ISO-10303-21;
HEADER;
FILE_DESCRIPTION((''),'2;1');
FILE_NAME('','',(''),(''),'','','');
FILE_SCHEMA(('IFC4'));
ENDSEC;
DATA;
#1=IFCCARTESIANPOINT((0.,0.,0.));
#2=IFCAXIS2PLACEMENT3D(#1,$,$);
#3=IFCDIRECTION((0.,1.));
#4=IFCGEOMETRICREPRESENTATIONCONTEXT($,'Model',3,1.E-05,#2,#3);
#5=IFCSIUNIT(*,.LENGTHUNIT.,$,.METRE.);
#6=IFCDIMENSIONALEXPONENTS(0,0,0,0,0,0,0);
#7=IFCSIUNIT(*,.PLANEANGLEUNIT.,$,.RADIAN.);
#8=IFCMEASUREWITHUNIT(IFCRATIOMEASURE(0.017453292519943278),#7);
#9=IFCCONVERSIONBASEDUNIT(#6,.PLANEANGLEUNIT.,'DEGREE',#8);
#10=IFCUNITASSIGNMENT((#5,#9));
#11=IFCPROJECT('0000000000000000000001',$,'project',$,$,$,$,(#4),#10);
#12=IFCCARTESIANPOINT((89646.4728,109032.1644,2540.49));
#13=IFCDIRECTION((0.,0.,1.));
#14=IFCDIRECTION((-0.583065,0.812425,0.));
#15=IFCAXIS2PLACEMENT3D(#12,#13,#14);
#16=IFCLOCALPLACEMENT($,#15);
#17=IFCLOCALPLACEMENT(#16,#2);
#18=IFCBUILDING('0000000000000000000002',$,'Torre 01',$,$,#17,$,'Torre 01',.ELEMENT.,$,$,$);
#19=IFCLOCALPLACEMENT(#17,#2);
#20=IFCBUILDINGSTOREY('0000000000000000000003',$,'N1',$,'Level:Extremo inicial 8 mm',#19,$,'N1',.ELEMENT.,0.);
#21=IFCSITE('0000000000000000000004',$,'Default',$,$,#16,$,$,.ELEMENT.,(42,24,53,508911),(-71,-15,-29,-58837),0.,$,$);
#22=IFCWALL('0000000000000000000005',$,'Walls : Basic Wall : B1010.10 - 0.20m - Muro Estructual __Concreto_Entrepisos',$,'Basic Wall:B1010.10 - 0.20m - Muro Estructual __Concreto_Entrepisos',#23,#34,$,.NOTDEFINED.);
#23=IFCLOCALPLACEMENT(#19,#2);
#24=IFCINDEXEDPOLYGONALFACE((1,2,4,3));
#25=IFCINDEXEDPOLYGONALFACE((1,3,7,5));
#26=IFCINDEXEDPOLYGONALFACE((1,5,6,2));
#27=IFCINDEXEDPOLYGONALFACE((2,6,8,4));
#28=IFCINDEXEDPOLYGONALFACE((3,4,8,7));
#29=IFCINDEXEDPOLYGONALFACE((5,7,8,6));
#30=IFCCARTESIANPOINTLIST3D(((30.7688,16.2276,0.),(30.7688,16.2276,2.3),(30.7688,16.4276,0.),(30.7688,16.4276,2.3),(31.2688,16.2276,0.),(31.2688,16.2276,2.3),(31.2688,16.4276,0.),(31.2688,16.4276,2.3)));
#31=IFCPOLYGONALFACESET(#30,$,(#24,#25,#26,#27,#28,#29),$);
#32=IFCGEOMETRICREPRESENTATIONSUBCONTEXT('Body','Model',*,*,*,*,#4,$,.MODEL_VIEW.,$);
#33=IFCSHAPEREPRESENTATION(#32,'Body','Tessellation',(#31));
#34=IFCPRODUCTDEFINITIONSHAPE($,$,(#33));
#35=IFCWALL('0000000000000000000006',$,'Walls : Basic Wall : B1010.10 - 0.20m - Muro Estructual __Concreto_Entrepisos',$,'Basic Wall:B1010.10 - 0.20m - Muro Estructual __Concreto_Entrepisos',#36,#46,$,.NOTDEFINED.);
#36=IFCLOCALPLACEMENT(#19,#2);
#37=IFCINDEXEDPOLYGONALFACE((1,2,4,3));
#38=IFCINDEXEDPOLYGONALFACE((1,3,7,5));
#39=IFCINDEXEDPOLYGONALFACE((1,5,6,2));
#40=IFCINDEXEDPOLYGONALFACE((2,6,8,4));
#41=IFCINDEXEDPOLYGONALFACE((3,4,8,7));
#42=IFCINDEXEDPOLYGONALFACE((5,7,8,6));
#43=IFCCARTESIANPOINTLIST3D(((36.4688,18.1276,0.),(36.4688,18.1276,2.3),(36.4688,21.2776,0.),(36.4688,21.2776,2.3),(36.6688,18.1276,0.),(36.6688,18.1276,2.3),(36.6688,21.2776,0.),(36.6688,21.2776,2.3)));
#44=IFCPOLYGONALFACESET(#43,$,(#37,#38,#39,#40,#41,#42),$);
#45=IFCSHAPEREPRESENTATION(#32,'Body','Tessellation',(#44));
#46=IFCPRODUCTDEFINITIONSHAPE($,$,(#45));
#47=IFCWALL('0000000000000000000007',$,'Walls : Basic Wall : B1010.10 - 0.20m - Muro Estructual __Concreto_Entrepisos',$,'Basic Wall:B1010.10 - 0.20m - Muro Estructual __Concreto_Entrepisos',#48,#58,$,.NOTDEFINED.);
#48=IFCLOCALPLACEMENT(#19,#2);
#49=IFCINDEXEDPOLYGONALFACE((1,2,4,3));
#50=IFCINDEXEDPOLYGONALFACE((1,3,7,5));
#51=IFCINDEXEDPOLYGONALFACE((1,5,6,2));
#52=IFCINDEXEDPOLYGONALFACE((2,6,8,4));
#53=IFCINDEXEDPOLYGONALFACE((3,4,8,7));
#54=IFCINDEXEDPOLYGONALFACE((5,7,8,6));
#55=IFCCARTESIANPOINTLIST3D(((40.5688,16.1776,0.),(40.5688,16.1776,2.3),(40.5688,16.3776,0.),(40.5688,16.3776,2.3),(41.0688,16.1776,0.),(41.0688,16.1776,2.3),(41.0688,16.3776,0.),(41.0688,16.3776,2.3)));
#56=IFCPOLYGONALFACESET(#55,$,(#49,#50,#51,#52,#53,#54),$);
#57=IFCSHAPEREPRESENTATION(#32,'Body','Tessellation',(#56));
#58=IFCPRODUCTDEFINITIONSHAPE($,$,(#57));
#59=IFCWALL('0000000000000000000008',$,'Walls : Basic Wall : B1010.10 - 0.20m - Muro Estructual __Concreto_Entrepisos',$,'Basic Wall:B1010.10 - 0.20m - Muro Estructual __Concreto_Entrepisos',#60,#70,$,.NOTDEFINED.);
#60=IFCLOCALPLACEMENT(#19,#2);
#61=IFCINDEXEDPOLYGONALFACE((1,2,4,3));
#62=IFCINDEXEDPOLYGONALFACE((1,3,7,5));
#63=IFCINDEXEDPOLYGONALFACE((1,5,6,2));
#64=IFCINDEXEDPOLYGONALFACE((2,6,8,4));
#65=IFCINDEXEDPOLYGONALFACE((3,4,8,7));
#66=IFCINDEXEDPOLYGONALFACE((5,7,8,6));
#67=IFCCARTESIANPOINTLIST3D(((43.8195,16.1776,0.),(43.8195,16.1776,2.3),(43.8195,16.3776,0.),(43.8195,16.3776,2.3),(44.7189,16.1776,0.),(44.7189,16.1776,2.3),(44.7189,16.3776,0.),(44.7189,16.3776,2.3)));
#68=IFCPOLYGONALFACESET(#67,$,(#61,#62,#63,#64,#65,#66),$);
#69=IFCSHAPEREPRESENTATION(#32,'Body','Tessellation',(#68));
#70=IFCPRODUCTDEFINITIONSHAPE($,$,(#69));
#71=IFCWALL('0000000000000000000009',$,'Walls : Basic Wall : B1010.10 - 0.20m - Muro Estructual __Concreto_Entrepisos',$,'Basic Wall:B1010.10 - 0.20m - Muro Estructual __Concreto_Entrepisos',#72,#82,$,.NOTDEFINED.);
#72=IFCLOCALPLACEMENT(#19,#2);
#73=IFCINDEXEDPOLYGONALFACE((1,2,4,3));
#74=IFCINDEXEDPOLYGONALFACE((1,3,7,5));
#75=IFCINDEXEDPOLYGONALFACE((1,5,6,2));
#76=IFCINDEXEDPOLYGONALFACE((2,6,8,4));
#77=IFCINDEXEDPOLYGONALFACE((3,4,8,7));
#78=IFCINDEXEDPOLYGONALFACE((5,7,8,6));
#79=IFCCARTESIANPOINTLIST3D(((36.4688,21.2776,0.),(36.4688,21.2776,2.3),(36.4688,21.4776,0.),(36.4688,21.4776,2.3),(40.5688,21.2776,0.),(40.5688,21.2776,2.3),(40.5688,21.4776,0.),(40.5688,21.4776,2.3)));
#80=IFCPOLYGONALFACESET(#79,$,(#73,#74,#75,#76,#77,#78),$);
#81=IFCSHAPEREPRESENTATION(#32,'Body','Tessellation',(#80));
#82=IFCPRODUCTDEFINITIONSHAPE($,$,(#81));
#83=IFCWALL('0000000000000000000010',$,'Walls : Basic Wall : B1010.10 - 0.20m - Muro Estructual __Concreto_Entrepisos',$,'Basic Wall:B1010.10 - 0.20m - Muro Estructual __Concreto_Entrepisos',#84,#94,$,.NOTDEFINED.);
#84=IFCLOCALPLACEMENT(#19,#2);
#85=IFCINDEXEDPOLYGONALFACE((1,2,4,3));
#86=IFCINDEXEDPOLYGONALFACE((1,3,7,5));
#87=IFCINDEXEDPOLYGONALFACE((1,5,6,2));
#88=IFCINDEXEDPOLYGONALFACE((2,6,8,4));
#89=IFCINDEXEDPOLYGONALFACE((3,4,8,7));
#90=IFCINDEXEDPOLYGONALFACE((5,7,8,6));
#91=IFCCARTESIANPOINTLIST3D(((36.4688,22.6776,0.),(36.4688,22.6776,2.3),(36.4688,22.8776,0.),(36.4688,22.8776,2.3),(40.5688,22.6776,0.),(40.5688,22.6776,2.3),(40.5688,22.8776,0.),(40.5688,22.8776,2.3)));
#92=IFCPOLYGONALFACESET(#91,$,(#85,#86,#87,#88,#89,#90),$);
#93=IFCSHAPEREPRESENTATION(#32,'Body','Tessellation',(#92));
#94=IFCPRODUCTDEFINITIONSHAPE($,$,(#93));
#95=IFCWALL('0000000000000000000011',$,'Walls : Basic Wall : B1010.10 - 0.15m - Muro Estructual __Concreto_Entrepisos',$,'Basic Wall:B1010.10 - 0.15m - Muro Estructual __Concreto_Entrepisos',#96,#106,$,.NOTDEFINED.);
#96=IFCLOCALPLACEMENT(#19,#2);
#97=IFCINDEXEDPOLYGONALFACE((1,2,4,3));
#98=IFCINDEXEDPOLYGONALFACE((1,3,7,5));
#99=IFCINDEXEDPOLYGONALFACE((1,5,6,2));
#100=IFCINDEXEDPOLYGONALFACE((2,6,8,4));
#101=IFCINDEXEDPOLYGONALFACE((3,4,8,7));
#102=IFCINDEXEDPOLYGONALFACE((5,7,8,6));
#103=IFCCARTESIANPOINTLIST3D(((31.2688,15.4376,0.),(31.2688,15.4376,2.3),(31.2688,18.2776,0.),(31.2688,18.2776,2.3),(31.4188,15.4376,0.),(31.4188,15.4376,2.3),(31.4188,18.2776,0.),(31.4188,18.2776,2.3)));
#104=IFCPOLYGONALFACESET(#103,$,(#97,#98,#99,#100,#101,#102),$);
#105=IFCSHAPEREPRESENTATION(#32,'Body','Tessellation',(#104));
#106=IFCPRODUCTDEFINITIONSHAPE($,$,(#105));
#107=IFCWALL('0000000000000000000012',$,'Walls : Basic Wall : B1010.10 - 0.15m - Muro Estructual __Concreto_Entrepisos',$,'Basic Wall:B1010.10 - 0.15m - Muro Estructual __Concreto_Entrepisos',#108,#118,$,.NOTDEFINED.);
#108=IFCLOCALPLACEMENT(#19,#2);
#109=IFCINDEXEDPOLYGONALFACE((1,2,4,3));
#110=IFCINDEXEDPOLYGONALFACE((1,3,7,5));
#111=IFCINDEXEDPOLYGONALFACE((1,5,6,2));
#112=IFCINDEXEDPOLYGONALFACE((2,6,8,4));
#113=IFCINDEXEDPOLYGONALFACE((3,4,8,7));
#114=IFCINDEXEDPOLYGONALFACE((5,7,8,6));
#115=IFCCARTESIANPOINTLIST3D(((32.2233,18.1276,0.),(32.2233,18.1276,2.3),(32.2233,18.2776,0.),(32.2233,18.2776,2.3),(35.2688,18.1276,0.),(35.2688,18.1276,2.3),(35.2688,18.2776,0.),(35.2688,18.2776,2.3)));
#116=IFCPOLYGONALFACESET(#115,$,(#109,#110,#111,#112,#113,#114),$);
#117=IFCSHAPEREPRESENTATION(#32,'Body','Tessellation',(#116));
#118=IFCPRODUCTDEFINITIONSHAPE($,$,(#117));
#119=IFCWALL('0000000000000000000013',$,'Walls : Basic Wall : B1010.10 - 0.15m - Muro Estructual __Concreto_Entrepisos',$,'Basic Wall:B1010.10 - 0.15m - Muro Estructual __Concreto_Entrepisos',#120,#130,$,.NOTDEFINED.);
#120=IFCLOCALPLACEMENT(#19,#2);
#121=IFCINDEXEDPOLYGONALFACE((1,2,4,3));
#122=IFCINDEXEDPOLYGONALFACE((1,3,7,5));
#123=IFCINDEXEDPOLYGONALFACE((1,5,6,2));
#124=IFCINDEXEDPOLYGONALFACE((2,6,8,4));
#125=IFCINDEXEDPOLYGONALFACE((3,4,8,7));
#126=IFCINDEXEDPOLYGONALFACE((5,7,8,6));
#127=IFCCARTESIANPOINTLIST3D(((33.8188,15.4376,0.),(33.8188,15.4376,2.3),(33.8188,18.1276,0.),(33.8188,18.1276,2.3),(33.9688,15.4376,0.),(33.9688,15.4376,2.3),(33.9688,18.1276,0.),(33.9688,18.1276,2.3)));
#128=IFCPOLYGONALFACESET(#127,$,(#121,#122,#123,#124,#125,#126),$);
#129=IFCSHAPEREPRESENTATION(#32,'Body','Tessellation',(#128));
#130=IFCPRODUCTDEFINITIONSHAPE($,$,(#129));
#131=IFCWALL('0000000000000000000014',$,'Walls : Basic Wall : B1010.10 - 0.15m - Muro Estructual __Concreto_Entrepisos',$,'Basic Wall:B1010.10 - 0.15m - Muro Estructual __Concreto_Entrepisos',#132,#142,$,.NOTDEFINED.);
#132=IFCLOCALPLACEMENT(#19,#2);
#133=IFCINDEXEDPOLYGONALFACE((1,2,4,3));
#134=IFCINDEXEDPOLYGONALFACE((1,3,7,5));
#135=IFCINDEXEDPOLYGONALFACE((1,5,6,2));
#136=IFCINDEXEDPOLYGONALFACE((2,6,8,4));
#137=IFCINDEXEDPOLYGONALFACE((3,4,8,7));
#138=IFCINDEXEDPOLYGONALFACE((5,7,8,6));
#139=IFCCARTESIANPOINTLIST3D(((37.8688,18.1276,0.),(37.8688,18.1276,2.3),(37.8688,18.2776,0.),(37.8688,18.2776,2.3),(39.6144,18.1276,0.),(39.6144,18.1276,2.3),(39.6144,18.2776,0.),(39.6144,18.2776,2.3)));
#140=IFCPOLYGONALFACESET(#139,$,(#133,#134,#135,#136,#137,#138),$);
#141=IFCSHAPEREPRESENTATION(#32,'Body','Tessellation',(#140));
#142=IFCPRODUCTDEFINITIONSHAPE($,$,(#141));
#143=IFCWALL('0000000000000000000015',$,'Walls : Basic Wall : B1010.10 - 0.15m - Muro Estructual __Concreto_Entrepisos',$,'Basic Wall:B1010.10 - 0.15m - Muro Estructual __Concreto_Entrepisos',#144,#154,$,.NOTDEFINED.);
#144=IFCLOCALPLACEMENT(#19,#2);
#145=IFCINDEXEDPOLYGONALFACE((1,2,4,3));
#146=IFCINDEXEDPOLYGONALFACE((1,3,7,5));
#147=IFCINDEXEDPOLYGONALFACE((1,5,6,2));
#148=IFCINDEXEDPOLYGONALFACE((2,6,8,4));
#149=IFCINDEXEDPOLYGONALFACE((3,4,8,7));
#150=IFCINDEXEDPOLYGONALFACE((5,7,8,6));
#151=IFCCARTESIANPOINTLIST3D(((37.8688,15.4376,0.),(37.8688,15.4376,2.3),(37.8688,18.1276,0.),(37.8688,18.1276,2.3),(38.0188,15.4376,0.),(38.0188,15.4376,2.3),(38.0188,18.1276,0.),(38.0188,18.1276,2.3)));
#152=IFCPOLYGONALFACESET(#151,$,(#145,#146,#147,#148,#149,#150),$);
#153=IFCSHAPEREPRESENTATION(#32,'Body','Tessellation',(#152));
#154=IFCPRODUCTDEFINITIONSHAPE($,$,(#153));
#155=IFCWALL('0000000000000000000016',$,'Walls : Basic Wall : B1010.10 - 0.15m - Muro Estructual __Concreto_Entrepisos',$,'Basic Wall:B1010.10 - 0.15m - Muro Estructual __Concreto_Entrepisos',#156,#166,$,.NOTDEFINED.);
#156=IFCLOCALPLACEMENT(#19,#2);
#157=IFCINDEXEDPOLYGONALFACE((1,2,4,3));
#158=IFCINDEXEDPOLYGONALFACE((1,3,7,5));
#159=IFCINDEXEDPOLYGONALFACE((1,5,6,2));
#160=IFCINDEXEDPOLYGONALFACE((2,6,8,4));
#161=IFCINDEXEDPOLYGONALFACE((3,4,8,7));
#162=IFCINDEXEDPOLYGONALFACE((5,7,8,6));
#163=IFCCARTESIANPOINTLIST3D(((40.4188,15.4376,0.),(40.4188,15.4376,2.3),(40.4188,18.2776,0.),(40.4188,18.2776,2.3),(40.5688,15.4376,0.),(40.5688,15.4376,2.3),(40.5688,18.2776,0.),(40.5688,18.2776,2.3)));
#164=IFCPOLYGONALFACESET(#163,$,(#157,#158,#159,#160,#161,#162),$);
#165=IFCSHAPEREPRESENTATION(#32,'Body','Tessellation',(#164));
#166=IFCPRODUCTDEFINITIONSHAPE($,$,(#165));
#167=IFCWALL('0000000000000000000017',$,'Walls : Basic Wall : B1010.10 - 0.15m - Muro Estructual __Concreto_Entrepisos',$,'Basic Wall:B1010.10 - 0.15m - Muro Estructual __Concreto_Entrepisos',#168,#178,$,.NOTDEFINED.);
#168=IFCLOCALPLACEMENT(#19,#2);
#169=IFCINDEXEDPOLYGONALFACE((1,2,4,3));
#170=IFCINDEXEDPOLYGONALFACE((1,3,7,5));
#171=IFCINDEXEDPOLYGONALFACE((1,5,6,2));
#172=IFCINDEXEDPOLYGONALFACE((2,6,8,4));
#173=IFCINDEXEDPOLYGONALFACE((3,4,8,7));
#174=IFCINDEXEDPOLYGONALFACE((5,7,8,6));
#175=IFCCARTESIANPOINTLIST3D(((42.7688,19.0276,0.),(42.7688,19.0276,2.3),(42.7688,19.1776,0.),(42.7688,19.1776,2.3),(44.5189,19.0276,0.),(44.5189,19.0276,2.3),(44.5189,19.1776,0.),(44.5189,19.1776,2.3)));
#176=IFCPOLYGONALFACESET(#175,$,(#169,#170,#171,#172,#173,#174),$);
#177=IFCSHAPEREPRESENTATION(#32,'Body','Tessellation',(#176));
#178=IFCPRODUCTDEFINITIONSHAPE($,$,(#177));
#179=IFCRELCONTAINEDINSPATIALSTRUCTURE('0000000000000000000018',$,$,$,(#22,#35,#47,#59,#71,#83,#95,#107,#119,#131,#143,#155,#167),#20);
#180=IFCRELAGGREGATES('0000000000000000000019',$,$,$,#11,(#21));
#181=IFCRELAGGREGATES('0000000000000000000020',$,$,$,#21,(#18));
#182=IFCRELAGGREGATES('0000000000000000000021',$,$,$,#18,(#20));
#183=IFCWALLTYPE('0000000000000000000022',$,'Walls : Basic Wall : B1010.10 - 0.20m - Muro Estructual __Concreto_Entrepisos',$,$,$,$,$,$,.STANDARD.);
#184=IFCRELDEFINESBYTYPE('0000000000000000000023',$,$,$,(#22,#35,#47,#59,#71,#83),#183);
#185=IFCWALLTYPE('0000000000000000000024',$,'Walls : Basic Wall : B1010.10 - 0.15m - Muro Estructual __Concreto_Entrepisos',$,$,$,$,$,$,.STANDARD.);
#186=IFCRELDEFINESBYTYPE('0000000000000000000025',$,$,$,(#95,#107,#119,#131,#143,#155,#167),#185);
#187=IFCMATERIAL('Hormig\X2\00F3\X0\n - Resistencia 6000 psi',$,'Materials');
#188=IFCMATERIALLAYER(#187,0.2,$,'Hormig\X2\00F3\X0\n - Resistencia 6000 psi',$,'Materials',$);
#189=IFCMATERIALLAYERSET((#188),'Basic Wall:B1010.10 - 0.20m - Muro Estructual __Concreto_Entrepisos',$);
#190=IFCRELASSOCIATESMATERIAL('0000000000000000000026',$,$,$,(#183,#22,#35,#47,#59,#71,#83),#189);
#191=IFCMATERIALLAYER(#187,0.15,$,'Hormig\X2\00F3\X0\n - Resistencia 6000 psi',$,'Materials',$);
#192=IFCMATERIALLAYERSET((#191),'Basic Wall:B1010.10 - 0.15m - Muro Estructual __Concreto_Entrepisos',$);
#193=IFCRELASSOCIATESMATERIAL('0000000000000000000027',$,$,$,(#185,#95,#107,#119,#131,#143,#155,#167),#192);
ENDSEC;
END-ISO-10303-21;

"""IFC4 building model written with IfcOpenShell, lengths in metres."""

from ifc_helpers import new_model, entity, si_unit, converted_unit, direction, frame, frame_2d, origin, place, context, subcontext, project, spatial, rectangle, extrude, material, layer, layer_set, layer_usage, type_object, element, save


model = new_model("IFC4")

# Units and contexts
model_context = context("Model", 3, precision=1e-05, world=origin(), true_north=direction((0.0, 1.0)))
body_context = subcontext(model_context, "Body", "Model", "MODEL_VIEW")
ifc_project = project(units=[si_unit("LENGTHUNIT", "METRE"), converted_unit("PLANEANGLEUNIT", "DEGREE", entity("IfcRatioMeasure", 0.017453292519943278), si_unit("PLANEANGLEUNIT", "RADIAN"), dimensions=[0, 0, 0, 0, 0, 0, 0])], contexts=[model_context])

# Site, building, storey
site_placement = place(None, frame((89646.4728, 109032.1644, 2540.49), z_axis=(0.0, 0.0, 1.0), x_axis=(-0.583065, 0.812425, 0.0)))
site = spatial("IfcSite", under=ifc_project, at=site_placement, Name="Default", CompositionType="ELEMENT", RefLatitude=(42, 24, 53, 508911), RefLongitude=(-71, -15, -29, -58837), RefElevation=0.0)
building_placement = place(site_placement, origin())
building = spatial("IfcBuilding", under=site, at=building_placement, Name="Torre 01", LongName="Torre 01", CompositionType="ELEMENT")
storey_placement = place(building_placement, origin())
storey = spatial("IfcBuildingStorey", under=building, at=storey_placement, Name="N1", ObjectType="Level:Extremo inicial 8 mm", LongName="N1", CompositionType="ELEMENT", Elevation=0.0)

# Walls
ifc_material_1 = material(Name="Hormigón - Resistencia 6000 psi", Category="Materials")
ifc_layer_1 = layer(ifc_material_1, 0.2, Name="Hormigón - Resistencia 6000 psi", Category="Materials")
ifc_layer_set_1 = layer_set([ifc_layer_1], Name="Basic Wall:B1010.10 - 0.20m - Muro Estructual __Concreto_Entrepisos")
ifc_layer_usage_1 = layer_usage(ifc_layer_set_1, "AXIS2", "NEGATIVE", 0.1)
wall_type_1 = type_object("IfcWallType", Name="Walls : Basic Wall : B1010.10 - 0.20m - Muro Estructual __Concreto_Entrepisos", PredefinedType="STANDARD", material=ifc_layer_set_1)
wall_1_placement = place(storey_placement, frame((30.7688, 16.3276, 0.0)))
element("IfcWall", 1, at=wall_1_placement, inside=storey, type_object=wall_type_1, material=ifc_layer_usage_1, Name="Walls : Basic Wall : B1010.10 - 0.20m - Muro Estructual __Concreto_Entrepisos", ObjectType="Basic Wall:B1010.10 - 0.20m - Muro Estructual __Concreto_Entrepisos", PredefinedType="NOTDEFINED", context=body_context, shape_type="SweptSolid", body=[
    extrude(rectangle(XDim=0.5, YDim=0.2, at=frame_2d((0.25, 0.0), x_axis=(-1.0, 0.0))), origin(), (0.0, 0.0, 1.0), 2.3),
])
ifc_layer_usage_2 = layer_usage(ifc_layer_set_1, "AXIS2", "NEGATIVE", 0.1)
wall_2_placement = place(storey_placement, frame((36.5688, 18.1276, 0.0), z_axis=(0.0, 0.0, 1.0), x_axis=(0.0, 1.0, 0.0)))
element("IfcWall", 2, at=wall_2_placement, inside=storey, type_object=wall_type_1, material=ifc_layer_usage_2, Name="Walls : Basic Wall : B1010.10 - 0.20m - Muro Estructual __Concreto_Entrepisos", ObjectType="Basic Wall:B1010.10 - 0.20m - Muro Estructual __Concreto_Entrepisos", PredefinedType="NOTDEFINED", context=body_context, shape_type="SweptSolid", body=[
    extrude(rectangle(XDim=3.15, YDim=0.2, at=frame_2d((1.575, 0.0), x_axis=(-1.0, 0.0))), origin(), (0.0, 0.0, 1.0), 2.3),
])
ifc_layer_usage_3 = layer_usage(ifc_layer_set_1, "AXIS2", "NEGATIVE", 0.1)
wall_3_placement = place(storey_placement, frame((41.0688, 16.2776, 0.0), z_axis=(0.0, 0.0, 1.0), x_axis=(-1.0, 0.0, 0.0)))
element("IfcWall", 3, at=wall_3_placement, inside=storey, type_object=wall_type_1, material=ifc_layer_usage_3, Name="Walls : Basic Wall : B1010.10 - 0.20m - Muro Estructual __Concreto_Entrepisos", ObjectType="Basic Wall:B1010.10 - 0.20m - Muro Estructual __Concreto_Entrepisos", PredefinedType="NOTDEFINED", context=body_context, shape_type="SweptSolid", body=[
    extrude(rectangle(XDim=0.5, YDim=0.2, at=frame_2d((0.25, 0.0), x_axis=(-1.0, 0.0))), origin(), (0.0, 0.0, 1.0), 2.3),
])
ifc_layer_usage_4 = layer_usage(ifc_layer_set_1, "AXIS2", "NEGATIVE", 0.1)
wall_4_placement = place(storey_placement, frame((43.8195, 16.2776, 0.0)))
element("IfcWall", 4, at=wall_4_placement, inside=storey, type_object=wall_type_1, material=ifc_layer_usage_4, Name="Walls : Basic Wall : B1010.10 - 0.20m - Muro Estructual __Concreto_Entrepisos", ObjectType="Basic Wall:B1010.10 - 0.20m - Muro Estructual __Concreto_Entrepisos", PredefinedType="NOTDEFINED", context=body_context, shape_type="SweptSolid", body=[
    extrude(rectangle(XDim=0.8993, YDim=0.2, at=frame_2d((0.4497, 0.0), x_axis=(-1.0, 0.0))), origin(), (0.0, 0.0, 1.0), 2.3),
])
ifc_layer_usage_5 = layer_usage(ifc_layer_set_1, "AXIS2", "NEGATIVE", 0.1)
wall_5_placement = place(storey_placement, frame((36.4688, 21.3776, 0.0)))
element("IfcWall", 5, at=wall_5_placement, inside=storey, type_object=wall_type_1, material=ifc_layer_usage_5, Name="Walls : Basic Wall : B1010.10 - 0.20m - Muro Estructual __Concreto_Entrepisos", ObjectType="Basic Wall:B1010.10 - 0.20m - Muro Estructual __Concreto_Entrepisos", PredefinedType="NOTDEFINED", context=body_context, shape_type="SweptSolid", body=[
    extrude(rectangle(XDim=4.1, YDim=0.2, at=frame_2d((2.05, 0.0), x_axis=(-1.0, 0.0))), origin(), (0.0, 0.0, 1.0), 2.3),
])
ifc_layer_usage_6 = layer_usage(ifc_layer_set_1, "AXIS2", "POSITIVE", -0.1)
wall_6_placement = place(storey_placement, frame((36.4688, 22.7776, 0.0)))
element("IfcWall", 6, at=wall_6_placement, inside=storey, type_object=wall_type_1, material=ifc_layer_usage_6, Name="Walls : Basic Wall : B1010.10 - 0.20m - Muro Estructual __Concreto_Entrepisos", ObjectType="Basic Wall:B1010.10 - 0.20m - Muro Estructual __Concreto_Entrepisos", PredefinedType="NOTDEFINED", context=body_context, shape_type="SweptSolid", body=[
    extrude(rectangle(XDim=4.1, YDim=0.2, at=frame_2d((2.05, 0.0), x_axis=(-1.0, 0.0))), origin(), (0.0, 0.0, 1.0), 2.3),
])
ifc_layer_2 = layer(ifc_material_1, 0.15, Name="Hormigón - Resistencia 6000 psi", Category="Materials")
ifc_layer_set_2 = layer_set([ifc_layer_2], Name="Basic Wall:B1010.10 - 0.15m - Muro Estructual __Concreto_Entrepisos")
ifc_layer_usage_7 = layer_usage(ifc_layer_set_2, "AXIS2", "NEGATIVE", 0.075)
wall_type_2 = type_object("IfcWallType", Name="Walls : Basic Wall : B1010.10 - 0.15m - Muro Estructual __Concreto_Entrepisos", PredefinedType="STANDARD", material=ifc_layer_set_2)
wall_7_placement = place(storey_placement, frame((31.3438, 15.4376, 0.0), z_axis=(0.0, 0.0, 1.0), x_axis=(0.0, 1.0, 0.0)))
element("IfcWall", 7, at=wall_7_placement, inside=storey, type_object=wall_type_2, material=ifc_layer_usage_7, Name="Walls : Basic Wall : B1010.10 - 0.15m - Muro Estructual __Concreto_Entrepisos", ObjectType="Basic Wall:B1010.10 - 0.15m - Muro Estructual __Concreto_Entrepisos", PredefinedType="NOTDEFINED", context=body_context, shape_type="SweptSolid", body=[
    extrude(rectangle(XDim=2.84, YDim=0.15, at=frame_2d((1.42, 0.0), x_axis=(-1.0, 0.0))), origin(), (0.0, 0.0, 1.0), 2.3),
])
ifc_layer_usage_8 = layer_usage(ifc_layer_set_2, "AXIS2", "NEGATIVE", 0.075)
wall_8_placement = place(storey_placement, frame((32.2233, 18.2026, 0.0)))
element("IfcWall", 8, at=wall_8_placement, inside=storey, type_object=wall_type_2, material=ifc_layer_usage_8, Name="Walls : Basic Wall : B1010.10 - 0.15m - Muro Estructual __Concreto_Entrepisos", ObjectType="Basic Wall:B1010.10 - 0.15m - Muro Estructual __Concreto_Entrepisos", PredefinedType="NOTDEFINED", context=body_context, shape_type="SweptSolid", body=[
    extrude(rectangle(XDim=3.0455, YDim=0.15, at=frame_2d((1.5228, 0.0), x_axis=(-1.0, 0.0))), origin(), (0.0, 0.0, 1.0), 2.3),
])
ifc_layer_usage_9 = layer_usage(ifc_layer_set_2, "AXIS2", "NEGATIVE", 0.075)
wall_9_placement = place(storey_placement, frame((33.8938, 18.1276, 0.0), z_axis=(0.0, 0.0, 1.0), x_axis=(0.0, -1.0, 0.0)))
element("IfcWall", 9, at=wall_9_placement, inside=storey, type_object=wall_type_2, material=ifc_layer_usage_9, Name="Walls : Basic Wall : B1010.10 - 0.15m - Muro Estructual __Concreto_Entrepisos", ObjectType="Basic Wall:B1010.10 - 0.15m - Muro Estructual __Concreto_Entrepisos", PredefinedType="NOTDEFINED", context=body_context, shape_type="SweptSolid", body=[
    extrude(rectangle(XDim=2.69, YDim=0.15, at=frame_2d((1.345, 0.0), x_axis=(-1.0, 0.0))), origin(), (0.0, 0.0, 1.0), 2.3),
])
ifc_layer_usage_10 = layer_usage(ifc_layer_set_2, "AXIS2", "NEGATIVE", 0.075)
wall_10_placement = place(storey_placement, frame((39.6144, 18.2026, 0.0), z_axis=(0.0, 0.0, 1.0), x_axis=(-1.0, 0.0, 0.0)))
element("IfcWall", 10, at=wall_10_placement, inside=storey, type_object=wall_type_2, material=ifc_layer_usage_10, Name="Walls : Basic Wall : B1010.10 - 0.15m - Muro Estructual __Concreto_Entrepisos", ObjectType="Basic Wall:B1010.10 - 0.15m - Muro Estructual __Concreto_Entrepisos", PredefinedType="NOTDEFINED", context=body_context, shape_type="SweptSolid", body=[
    extrude(rectangle(XDim=1.7455, YDim=0.15, at=frame_2d((0.8728, 0.0), x_axis=(-1.0, 0.0))), origin(), (0.0, 0.0, 1.0), 2.3),
])
ifc_layer_usage_11 = layer_usage(ifc_layer_set_2, "AXIS2", "NEGATIVE", 0.075)
wall_11_placement = place(storey_placement, frame((37.9438, 18.1276, 0.0), z_axis=(0.0, 0.0, 1.0), x_axis=(0.0, -1.0, 0.0)))
element("IfcWall", 11, at=wall_11_placement, inside=storey, type_object=wall_type_2, material=ifc_layer_usage_11, Name="Walls : Basic Wall : B1010.10 - 0.15m - Muro Estructual __Concreto_Entrepisos", ObjectType="Basic Wall:B1010.10 - 0.15m - Muro Estructual __Concreto_Entrepisos", PredefinedType="NOTDEFINED", context=body_context, shape_type="SweptSolid", body=[
    extrude(rectangle(XDim=2.69, YDim=0.15, at=frame_2d((1.345, 0.0), x_axis=(-1.0, 0.0))), origin(), (0.0, 0.0, 1.0), 2.3),
])
ifc_layer_usage_12 = layer_usage(ifc_layer_set_2, "AXIS2", "NEGATIVE", 0.075)
wall_12_placement = place(storey_placement, frame((40.4938, 18.2776, 0.0), z_axis=(0.0, 0.0, 1.0), x_axis=(0.0, -1.0, 0.0)))
element("IfcWall", 12, at=wall_12_placement, inside=storey, type_object=wall_type_2, material=ifc_layer_usage_12, Name="Walls : Basic Wall : B1010.10 - 0.15m - Muro Estructual __Concreto_Entrepisos", ObjectType="Basic Wall:B1010.10 - 0.15m - Muro Estructual __Concreto_Entrepisos", PredefinedType="NOTDEFINED", context=body_context, shape_type="SweptSolid", body=[
    extrude(rectangle(XDim=2.84, YDim=0.15, at=frame_2d((1.42, 0.0), x_axis=(-1.0, 0.0))), origin(), (0.0, 0.0, 1.0), 2.3),
])
ifc_layer_usage_13 = layer_usage(ifc_layer_set_2, "AXIS2", "POSITIVE", -0.075)
wall_13_placement = place(storey_placement, frame((42.7688, 19.1026, 0.0)))
element("IfcWall", 13, at=wall_13_placement, inside=storey, type_object=wall_type_2, material=ifc_layer_usage_13, Name="Walls : Basic Wall : B1010.10 - 0.15m - Muro Estructual __Concreto_Entrepisos", ObjectType="Basic Wall:B1010.10 - 0.15m - Muro Estructual __Concreto_Entrepisos", PredefinedType="NOTDEFINED", context=body_context, shape_type="SweptSolid", body=[
    extrude(rectangle(XDim=1.75, YDim=0.15, at=frame_2d((0.875, 0.0), x_axis=(-1.0, 0.0))), origin(), (0.0, 0.0, 1.0), 2.3),
])

save(model, "model.ifc")
